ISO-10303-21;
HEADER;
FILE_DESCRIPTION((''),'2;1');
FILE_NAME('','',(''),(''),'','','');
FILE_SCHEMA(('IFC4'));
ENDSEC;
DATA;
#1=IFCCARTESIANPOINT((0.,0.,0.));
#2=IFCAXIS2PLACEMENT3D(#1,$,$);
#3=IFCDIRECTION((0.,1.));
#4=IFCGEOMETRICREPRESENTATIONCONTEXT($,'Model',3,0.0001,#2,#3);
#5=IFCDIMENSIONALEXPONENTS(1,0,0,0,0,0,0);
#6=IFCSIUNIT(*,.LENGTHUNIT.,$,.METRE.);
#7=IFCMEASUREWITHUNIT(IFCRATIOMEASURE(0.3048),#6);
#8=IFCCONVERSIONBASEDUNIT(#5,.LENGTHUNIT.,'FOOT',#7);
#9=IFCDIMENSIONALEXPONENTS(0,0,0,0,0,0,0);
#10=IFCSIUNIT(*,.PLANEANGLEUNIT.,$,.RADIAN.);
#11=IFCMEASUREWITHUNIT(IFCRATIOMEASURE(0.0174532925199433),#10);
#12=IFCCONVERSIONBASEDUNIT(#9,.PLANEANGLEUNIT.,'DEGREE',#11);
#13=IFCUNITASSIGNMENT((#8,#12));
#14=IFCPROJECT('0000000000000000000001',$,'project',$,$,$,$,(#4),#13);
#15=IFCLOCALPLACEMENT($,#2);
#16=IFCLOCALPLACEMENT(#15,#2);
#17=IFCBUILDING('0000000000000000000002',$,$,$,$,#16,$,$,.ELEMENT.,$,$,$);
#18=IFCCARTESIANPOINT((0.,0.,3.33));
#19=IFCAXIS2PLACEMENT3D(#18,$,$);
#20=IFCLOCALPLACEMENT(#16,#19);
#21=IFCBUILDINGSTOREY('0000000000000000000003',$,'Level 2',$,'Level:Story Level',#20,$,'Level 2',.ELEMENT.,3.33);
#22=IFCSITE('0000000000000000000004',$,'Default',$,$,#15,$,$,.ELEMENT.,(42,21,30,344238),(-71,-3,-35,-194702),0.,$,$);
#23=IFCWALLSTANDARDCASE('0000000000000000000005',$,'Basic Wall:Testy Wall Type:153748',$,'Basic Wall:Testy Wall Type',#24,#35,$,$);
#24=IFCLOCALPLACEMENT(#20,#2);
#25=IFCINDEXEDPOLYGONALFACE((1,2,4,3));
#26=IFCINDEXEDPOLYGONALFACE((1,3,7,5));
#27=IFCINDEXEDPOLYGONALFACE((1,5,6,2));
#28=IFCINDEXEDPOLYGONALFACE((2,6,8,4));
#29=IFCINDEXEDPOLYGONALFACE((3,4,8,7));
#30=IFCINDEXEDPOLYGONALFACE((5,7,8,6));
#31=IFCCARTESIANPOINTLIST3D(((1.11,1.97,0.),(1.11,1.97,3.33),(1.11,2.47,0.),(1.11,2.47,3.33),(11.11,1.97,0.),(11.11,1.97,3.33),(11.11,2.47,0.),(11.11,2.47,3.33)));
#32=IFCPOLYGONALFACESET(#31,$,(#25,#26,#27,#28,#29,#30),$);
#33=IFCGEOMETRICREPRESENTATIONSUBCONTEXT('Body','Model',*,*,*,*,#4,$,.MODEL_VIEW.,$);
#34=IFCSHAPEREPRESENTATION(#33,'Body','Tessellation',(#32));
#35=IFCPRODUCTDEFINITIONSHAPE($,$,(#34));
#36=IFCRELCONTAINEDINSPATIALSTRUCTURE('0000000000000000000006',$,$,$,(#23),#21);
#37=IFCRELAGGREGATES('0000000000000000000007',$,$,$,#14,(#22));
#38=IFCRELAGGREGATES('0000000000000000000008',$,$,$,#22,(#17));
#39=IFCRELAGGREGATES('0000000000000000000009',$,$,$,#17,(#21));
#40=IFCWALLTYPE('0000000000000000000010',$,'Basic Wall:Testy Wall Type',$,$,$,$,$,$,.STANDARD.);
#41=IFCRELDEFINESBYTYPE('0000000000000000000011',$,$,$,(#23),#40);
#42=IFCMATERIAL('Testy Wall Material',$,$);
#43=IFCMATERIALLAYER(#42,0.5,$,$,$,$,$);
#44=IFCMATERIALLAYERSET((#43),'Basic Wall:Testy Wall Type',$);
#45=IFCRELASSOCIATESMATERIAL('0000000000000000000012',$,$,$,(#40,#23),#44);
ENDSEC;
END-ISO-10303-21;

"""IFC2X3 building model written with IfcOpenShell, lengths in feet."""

from ifc_helpers import new_model, entity, si_unit, converted_unit, direction, frame, frame_2d, origin, place, context, subcontext, project, spatial, rectangle, extrude, material, layer, layer_set, layer_usage, type_object, element, save


model = new_model("IFC2X3")

# Units and contexts
model_context = context("Model", 3, precision=0.0001, world=origin(), true_north=direction((0.0, 1.0)))
body_context = subcontext(model_context, "Body", "Model", "MODEL_VIEW")
ifc_project = project(units=[converted_unit("LENGTHUNIT", "FOOT", entity("IfcRatioMeasure", 0.3048), si_unit("LENGTHUNIT", "METRE"), dimensions=[1, 0, 0, 0, 0, 0, 0]), converted_unit("PLANEANGLEUNIT", "DEGREE", entity("IfcRatioMeasure", 0.0174532925199433), si_unit("PLANEANGLEUNIT", "RADIAN"), dimensions=[0, 0, 0, 0, 0, 0, 0])], contexts=[model_context])

# Site, building, storey
site_placement = place(None, origin())
site = spatial("IfcSite", under=ifc_project, at=site_placement, Name="Default", CompositionType="ELEMENT", RefLatitude=(42, 21, 30, 344238), RefLongitude=(-71, -3, -35, -194702), RefElevation=0.0)
building_placement = place(site_placement, origin())
building = spatial("IfcBuilding", under=site, at=building_placement, CompositionType="ELEMENT")
storey_placement = place(building_placement, frame((0.0, 0.0, 3.33)))
storey = spatial("IfcBuildingStorey", under=building, at=storey_placement, Name="Level 2", ObjectType="Level:Story Level", LongName="Level 2", CompositionType="ELEMENT", Elevation=3.33)

# Wall
ifc_material = material(Name="Testy Wall Material")
ifc_layer = layer(ifc_material, 0.5)
ifc_layer_set = layer_set([ifc_layer], Name="Basic Wall:Testy Wall Type")
ifc_layer_usage = layer_usage(ifc_layer_set, "AXIS2", "NEGATIVE", 0.25)
wall_type = type_object("IfcWallType", Name="Basic Wall:Testy Wall Type", PredefinedType="STANDARD", material=ifc_layer_set)
wall_placement = place(storey_placement, frame((1.11, 2.22, 0.0)))
element("IfcWallStandardCase", 1, at=wall_placement, inside=storey, type_object=wall_type, material=ifc_layer_usage, Name="Basic Wall:Testy Wall Type:153748", ObjectType="Basic Wall:Testy Wall Type", context=body_context, shape_type="SweptSolid", body=[
    extrude(rectangle(XDim=10.0, YDim=0.5, at=frame_2d((5.0, 0.0), x_axis=(-1.0, 0.0))), origin(), (0.0, 0.0, 1.0), 3.33),
])

save(model, "model.ifc")
